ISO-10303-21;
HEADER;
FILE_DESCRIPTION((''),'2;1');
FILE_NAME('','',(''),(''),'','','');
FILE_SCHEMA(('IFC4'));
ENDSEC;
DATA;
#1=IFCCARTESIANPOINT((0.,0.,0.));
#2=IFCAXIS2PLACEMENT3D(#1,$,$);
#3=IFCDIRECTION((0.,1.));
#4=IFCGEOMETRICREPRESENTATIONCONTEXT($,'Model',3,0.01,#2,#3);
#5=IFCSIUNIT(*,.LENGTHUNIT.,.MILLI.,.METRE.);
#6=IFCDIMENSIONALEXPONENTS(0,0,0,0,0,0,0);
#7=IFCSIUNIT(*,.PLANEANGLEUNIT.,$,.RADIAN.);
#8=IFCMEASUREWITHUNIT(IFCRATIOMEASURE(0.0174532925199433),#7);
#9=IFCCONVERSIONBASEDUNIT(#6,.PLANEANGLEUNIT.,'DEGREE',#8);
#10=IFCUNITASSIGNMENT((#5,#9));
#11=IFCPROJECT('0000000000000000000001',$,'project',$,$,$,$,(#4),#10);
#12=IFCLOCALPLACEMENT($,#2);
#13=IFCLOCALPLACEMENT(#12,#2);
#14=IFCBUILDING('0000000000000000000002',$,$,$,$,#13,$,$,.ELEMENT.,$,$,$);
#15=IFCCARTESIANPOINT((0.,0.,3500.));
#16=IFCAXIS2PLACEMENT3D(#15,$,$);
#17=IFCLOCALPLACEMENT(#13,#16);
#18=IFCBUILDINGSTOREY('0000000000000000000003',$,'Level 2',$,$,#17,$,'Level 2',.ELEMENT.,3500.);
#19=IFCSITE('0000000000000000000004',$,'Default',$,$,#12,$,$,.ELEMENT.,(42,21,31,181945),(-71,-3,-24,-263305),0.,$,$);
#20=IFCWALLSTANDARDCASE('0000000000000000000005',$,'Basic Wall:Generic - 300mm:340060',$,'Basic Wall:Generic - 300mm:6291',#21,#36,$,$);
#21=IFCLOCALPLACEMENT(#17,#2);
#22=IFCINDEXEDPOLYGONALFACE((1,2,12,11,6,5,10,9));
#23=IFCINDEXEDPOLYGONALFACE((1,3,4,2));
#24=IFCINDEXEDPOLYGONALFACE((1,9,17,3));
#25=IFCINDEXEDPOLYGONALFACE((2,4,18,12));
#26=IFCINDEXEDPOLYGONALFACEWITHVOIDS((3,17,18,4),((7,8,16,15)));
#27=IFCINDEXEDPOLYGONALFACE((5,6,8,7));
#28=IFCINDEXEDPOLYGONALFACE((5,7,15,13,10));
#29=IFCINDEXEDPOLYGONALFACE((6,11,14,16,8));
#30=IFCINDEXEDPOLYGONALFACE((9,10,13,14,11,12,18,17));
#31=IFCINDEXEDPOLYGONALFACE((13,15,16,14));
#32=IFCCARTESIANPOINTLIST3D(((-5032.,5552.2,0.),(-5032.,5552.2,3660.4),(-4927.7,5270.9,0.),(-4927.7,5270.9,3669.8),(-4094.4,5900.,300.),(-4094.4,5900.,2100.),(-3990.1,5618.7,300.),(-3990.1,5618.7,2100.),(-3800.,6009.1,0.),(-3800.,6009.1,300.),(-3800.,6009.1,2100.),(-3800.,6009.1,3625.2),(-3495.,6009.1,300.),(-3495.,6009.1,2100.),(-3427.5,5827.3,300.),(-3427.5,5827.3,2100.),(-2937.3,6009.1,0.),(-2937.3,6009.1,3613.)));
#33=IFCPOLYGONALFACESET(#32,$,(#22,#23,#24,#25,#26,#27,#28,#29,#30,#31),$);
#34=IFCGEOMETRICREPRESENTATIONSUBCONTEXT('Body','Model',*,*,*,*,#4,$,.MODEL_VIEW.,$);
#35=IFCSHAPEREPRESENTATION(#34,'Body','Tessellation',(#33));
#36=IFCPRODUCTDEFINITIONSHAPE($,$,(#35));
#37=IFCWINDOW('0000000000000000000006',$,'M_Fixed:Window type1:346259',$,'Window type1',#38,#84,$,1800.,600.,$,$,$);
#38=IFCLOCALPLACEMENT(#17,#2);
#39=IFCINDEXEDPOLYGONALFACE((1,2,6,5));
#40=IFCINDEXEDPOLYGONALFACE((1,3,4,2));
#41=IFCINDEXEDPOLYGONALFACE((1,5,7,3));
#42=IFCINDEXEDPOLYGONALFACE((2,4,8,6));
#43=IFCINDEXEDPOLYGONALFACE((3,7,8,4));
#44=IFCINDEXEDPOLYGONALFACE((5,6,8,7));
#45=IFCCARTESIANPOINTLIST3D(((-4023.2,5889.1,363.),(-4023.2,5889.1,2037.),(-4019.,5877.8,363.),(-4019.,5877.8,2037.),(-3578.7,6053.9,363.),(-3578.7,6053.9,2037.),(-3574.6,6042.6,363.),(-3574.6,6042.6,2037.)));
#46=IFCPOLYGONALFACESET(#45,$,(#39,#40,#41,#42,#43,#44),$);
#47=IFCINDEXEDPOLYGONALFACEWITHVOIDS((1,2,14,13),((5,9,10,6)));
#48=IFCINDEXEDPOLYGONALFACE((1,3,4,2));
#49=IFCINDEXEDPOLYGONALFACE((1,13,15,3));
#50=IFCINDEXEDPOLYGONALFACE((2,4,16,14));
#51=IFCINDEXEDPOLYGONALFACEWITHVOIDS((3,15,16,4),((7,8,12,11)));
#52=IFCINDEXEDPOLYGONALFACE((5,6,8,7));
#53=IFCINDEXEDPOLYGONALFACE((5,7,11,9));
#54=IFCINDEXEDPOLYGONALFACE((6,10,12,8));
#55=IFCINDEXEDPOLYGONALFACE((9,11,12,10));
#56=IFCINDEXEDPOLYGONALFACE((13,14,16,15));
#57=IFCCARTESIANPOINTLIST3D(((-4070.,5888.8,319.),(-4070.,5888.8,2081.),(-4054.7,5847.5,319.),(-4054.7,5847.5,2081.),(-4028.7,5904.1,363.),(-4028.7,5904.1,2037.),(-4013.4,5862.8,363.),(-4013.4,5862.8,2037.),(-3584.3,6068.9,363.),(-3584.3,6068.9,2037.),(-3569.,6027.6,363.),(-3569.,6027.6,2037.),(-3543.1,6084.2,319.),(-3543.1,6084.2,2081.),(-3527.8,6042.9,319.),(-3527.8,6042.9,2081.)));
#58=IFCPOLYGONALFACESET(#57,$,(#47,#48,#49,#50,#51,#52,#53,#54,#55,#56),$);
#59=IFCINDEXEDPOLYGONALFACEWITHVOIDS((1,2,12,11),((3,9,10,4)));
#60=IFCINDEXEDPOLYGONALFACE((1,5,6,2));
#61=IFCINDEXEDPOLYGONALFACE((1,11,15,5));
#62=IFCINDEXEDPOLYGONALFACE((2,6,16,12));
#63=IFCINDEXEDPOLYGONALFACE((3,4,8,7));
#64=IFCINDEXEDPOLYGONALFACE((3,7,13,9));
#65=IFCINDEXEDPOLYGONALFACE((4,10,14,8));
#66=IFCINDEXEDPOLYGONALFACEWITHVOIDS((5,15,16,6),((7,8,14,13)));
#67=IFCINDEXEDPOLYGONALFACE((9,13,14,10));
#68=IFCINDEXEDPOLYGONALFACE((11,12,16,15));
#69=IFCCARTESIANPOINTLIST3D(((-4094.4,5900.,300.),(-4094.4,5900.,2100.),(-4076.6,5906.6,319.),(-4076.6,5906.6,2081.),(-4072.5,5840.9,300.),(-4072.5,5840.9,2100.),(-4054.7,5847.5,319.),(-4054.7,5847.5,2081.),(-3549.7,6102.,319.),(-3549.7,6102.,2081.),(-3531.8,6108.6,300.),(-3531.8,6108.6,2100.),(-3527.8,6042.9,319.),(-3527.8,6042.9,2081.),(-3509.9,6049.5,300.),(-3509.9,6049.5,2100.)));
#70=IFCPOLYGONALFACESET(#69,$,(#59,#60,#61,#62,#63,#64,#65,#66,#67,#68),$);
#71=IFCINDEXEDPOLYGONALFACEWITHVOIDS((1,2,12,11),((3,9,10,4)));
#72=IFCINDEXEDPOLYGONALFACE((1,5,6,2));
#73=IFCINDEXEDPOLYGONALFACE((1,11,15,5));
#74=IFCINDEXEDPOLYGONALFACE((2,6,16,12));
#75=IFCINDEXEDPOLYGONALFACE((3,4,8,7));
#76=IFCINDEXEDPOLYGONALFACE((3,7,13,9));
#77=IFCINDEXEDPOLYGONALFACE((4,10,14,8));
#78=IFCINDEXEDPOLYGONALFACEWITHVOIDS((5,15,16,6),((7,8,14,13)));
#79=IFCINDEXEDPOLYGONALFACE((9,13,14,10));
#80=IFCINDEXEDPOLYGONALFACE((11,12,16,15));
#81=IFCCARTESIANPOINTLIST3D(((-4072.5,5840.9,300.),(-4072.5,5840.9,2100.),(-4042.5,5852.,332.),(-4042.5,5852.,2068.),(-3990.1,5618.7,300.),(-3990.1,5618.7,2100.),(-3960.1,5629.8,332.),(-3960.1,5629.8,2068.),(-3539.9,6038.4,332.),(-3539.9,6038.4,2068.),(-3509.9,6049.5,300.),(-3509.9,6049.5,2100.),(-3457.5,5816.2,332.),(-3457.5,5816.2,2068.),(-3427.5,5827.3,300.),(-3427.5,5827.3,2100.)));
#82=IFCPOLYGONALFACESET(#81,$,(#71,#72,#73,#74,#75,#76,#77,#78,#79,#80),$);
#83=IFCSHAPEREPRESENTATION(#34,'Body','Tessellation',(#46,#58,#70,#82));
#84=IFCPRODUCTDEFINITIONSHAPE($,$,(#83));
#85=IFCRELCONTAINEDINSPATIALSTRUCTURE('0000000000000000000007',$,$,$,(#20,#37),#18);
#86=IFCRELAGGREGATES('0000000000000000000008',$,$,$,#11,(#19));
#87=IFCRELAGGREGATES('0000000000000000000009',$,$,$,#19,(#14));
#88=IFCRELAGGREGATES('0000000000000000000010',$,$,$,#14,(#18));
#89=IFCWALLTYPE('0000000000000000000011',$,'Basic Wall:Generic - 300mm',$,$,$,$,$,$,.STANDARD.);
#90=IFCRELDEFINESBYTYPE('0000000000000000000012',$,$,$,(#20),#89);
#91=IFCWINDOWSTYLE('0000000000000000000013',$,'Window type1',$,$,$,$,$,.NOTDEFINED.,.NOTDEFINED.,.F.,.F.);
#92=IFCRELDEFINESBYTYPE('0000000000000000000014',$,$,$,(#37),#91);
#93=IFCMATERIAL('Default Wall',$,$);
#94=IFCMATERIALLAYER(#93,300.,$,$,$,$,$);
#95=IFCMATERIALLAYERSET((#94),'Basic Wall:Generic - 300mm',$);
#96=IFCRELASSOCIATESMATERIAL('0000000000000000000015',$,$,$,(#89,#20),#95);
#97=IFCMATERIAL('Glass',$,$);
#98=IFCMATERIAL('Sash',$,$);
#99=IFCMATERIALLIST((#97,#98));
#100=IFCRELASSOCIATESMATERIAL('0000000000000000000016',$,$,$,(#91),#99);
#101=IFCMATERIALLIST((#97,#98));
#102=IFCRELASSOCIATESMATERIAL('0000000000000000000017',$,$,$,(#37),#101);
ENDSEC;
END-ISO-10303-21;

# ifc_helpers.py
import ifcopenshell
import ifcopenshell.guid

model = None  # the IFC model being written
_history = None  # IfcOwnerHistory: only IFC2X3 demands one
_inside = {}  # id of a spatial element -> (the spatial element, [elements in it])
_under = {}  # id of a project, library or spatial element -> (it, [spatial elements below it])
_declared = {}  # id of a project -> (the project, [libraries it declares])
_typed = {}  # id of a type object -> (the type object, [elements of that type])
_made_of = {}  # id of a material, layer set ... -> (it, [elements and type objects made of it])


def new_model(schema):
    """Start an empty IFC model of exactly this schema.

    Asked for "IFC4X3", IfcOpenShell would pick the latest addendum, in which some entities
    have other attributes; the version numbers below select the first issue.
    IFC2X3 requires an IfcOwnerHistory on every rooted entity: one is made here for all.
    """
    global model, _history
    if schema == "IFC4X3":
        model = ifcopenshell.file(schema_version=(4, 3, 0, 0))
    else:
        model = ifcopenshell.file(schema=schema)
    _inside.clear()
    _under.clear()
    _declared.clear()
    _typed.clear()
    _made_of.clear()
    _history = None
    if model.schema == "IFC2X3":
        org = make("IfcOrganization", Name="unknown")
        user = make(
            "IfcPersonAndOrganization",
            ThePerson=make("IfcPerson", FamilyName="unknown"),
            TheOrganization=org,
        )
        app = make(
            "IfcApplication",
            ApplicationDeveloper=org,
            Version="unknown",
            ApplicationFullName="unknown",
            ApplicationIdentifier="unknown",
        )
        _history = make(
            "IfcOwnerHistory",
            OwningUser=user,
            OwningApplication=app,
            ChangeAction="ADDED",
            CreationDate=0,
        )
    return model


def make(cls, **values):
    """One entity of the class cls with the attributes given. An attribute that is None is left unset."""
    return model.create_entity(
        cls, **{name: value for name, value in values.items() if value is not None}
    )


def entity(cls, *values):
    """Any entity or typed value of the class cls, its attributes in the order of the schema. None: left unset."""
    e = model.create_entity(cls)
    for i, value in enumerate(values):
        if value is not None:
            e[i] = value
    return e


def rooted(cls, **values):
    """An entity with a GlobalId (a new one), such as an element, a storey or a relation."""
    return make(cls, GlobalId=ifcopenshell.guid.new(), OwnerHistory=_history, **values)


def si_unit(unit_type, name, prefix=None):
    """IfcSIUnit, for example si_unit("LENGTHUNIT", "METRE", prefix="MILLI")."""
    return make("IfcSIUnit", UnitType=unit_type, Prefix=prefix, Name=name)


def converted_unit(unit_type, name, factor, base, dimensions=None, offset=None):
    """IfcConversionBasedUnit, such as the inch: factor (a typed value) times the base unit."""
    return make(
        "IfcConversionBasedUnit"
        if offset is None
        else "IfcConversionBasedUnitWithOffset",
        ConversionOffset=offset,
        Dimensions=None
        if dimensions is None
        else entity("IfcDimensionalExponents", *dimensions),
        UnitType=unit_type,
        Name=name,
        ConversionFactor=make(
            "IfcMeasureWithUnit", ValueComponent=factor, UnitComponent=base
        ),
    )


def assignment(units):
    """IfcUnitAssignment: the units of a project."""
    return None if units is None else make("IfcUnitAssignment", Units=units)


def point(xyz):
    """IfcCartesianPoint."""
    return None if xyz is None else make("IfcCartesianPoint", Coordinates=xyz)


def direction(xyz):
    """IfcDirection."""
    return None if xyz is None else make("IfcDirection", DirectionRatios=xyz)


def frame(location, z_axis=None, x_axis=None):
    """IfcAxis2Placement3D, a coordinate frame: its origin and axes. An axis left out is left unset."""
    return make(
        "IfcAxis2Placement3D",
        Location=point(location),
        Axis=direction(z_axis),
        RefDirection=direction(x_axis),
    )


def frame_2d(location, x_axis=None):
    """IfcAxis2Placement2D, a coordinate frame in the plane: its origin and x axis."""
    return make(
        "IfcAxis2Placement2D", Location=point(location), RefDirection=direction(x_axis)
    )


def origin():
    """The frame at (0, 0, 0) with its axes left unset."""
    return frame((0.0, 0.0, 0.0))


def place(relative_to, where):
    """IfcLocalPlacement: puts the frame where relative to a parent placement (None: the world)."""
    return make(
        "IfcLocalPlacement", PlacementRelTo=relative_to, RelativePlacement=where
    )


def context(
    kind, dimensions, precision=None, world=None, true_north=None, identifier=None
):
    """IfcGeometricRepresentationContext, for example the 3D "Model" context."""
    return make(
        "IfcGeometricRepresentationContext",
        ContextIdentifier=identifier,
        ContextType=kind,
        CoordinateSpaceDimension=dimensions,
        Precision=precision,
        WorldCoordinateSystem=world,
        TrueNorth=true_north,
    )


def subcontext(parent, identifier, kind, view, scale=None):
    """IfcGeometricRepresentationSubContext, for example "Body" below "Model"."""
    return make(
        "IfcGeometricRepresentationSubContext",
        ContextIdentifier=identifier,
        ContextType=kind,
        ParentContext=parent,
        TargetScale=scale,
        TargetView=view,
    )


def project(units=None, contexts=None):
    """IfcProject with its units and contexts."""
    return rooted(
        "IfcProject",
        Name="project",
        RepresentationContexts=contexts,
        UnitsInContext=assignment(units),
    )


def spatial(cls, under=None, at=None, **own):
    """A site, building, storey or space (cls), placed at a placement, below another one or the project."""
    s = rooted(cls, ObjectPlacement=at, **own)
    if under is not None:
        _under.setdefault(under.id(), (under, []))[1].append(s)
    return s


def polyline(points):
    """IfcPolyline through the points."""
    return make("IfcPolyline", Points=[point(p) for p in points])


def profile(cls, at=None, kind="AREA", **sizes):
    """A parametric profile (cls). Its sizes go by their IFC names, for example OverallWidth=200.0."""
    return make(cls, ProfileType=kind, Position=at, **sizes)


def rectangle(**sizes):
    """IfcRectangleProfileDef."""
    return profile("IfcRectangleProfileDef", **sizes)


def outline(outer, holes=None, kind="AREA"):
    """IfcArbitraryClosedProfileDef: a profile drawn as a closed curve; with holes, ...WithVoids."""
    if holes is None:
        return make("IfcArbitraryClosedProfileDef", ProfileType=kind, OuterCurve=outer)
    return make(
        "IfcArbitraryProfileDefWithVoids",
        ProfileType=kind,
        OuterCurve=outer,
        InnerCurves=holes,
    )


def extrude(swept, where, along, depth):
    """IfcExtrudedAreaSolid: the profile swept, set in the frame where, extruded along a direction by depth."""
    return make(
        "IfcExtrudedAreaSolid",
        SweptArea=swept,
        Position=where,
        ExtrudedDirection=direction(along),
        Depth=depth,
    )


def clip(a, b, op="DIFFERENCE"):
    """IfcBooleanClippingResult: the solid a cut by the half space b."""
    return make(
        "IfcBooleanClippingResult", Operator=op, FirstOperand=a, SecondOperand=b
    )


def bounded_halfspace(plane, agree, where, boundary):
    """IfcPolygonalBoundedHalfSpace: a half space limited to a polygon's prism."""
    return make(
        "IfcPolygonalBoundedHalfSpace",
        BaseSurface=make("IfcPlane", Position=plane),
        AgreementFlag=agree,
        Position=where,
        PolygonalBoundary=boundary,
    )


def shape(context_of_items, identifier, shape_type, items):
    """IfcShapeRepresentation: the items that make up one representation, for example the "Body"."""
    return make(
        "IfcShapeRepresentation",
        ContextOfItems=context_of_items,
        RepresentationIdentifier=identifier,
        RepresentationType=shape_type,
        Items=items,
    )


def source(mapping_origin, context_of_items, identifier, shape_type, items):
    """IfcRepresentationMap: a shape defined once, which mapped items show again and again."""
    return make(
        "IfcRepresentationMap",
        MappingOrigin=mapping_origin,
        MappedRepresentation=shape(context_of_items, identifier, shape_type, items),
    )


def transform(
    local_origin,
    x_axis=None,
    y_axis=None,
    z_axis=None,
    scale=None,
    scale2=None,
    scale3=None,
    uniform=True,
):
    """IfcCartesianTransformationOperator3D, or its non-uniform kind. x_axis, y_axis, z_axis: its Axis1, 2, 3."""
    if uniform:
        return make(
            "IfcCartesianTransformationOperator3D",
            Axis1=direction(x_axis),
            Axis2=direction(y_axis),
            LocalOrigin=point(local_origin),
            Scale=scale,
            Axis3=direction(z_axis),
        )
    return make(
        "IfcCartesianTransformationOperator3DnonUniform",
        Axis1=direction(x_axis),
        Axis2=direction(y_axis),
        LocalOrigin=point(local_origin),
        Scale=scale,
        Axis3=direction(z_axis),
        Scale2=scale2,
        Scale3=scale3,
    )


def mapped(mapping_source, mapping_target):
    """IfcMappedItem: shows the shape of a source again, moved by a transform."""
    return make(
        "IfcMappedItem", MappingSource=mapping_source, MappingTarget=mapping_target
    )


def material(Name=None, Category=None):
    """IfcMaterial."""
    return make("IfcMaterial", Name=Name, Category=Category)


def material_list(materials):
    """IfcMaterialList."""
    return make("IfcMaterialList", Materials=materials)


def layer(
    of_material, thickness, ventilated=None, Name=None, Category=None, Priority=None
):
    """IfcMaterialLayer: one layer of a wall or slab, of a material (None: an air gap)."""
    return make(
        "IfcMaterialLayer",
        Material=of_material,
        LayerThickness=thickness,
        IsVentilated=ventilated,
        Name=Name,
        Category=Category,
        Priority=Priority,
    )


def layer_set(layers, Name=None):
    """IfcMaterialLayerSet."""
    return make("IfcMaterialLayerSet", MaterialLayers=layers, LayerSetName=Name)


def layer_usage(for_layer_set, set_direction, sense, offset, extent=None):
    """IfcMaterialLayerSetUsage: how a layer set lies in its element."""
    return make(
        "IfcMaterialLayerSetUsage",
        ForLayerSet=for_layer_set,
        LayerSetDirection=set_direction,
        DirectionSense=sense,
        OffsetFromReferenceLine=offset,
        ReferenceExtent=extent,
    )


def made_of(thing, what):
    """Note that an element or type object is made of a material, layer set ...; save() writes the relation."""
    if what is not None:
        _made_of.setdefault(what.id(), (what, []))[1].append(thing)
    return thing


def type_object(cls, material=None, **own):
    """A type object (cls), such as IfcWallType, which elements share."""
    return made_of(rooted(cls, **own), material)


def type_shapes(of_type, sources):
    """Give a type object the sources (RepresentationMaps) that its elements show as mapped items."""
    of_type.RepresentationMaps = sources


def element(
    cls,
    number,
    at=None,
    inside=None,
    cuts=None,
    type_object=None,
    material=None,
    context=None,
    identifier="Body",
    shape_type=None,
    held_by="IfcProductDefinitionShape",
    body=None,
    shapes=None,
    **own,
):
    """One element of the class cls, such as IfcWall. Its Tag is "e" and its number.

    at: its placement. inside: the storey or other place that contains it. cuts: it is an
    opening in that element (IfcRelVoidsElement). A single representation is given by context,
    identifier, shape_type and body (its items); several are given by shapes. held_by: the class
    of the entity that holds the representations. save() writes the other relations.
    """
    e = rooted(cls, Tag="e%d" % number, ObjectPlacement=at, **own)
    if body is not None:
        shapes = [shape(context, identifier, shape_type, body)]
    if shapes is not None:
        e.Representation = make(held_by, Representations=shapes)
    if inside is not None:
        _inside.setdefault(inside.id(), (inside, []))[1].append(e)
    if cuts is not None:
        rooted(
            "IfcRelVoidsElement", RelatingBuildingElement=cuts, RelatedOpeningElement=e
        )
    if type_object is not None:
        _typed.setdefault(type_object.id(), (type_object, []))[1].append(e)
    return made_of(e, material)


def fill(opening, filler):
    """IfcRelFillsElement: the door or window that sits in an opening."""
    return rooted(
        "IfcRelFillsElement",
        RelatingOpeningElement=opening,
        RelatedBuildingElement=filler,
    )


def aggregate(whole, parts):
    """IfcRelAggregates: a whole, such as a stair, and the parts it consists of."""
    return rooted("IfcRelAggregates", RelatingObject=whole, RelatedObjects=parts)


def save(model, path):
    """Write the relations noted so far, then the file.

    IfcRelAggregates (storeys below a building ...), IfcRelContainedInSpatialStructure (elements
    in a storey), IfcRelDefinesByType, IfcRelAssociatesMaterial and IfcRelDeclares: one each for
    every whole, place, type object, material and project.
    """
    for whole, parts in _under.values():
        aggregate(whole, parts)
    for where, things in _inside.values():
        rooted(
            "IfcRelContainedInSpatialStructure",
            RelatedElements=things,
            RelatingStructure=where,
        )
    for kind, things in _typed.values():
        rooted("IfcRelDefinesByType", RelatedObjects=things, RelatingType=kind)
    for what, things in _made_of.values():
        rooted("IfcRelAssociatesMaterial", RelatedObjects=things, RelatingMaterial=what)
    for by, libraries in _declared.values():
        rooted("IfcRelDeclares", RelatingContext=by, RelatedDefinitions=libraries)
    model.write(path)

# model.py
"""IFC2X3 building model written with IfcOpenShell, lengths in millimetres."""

from ifc_helpers import new_model, entity, si_unit, converted_unit, direction, frame, frame_2d, origin, place, context, subcontext, project, spatial, polyline, rectangle, outline, extrude, clip, bounded_halfspace, source, transform, mapped, material, material_list, layer, layer_set, layer_usage, type_object, type_shapes, element, fill, save


model = new_model("IFC2X3")

# Units and contexts
model_context = context("Model", 3, precision=0.01, world=origin(), true_north=direction((0.0, 1.0)))
body_context = subcontext(model_context, "Body", "Model", "MODEL_VIEW")
ifc_project = project(units=[si_unit("LENGTHUNIT", "METRE", prefix="MILLI"), converted_unit("PLANEANGLEUNIT", "DEGREE", entity("IfcRatioMeasure", 0.0174532925199433), si_unit("PLANEANGLEUNIT", "RADIAN"), dimensions=[0, 0, 0, 0, 0, 0, 0])], contexts=[model_context])

# Site, building, storey
site_placement = place(None, origin())
site = spatial("IfcSite", under=ifc_project, at=site_placement, Name="Default", CompositionType="ELEMENT", RefLatitude=(42, 21, 31, 181945), RefLongitude=(-71, -3, -24, -263305), RefElevation=0.0)
building_placement = place(site_placement, origin())
building = spatial("IfcBuilding", under=site, at=building_placement, CompositionType="ELEMENT")
storey_placement = place(building_placement, frame((0.0, 0.0, 3500.0)))
storey = spatial("IfcBuildingStorey", under=building, at=storey_placement, Name="Level 2", LongName="Level 2", CompositionType="ELEMENT", Elevation=3500.0)

# Shared definitions
ifc_material_1 = material(Name="Default Wall")
ifc_layer_1 = layer(ifc_material_1, 300.0)
ifc_layer_set_1 = layer_set([ifc_layer_1], Name="Basic Wall:Generic - 300mm")
wall_type = type_object("IfcWallType", Name="Basic Wall:Generic - 300mm", PredefinedType="STANDARD", material=ifc_layer_set_1)
ifc_material_2 = material(Name="Glass")
ifc_material_3 = material(Name="Sash")

# Wall, opening, window
ifc_layer_usage_1 = layer_usage(ifc_layer_set_1, "AXIS2", "NEGATIVE", 150.0)
wall_1_placement = place(storey_placement, frame((-4979.8, 5411.6, 0.0), z_axis=(0.0, 0.0, 1.0), x_axis=(0.937589, 0.347744, 0.0)))
wall_1 = element("IfcWallStandardCase", 1, at=wall_1_placement, inside=storey, type_object=wall_type, material=ifc_layer_usage_1, Name="Basic Wall:Generic - 300mm:340060", ObjectType="Basic Wall:Generic - 300mm:6291", context=body_context, shape_type="Clipping", body=[
    clip(extrude(outline(polyline([(2122.8, -150.0), (1314.0, 150.0), (0.0, 150.0), (0.0, -150.0), (2122.8, -150.0)])), origin(), (0.0, 0.0, 1.0), 3669.8), bounded_halfspace(frame((0.0, -150.0, 3669.8), z_axis=(0.026731, 0.031465, 0.999147), x_axis=(-0.76211, 0.647447, 0.0)), False, frame((0.0, -150.0, 3669.8)), polyline([(0.0, 0.0), (2122.8, 0.0), (1314.0, 300.0), (0.0, 300.0), (0.0, 0.0)]))),
])
opening_1_placement = place(wall_1_placement, frame((1000.0, -150.0, 300.0)))
opening_1 = element("IfcOpeningElement", 2, at=opening_1_placement, cuts=wall_1, ObjectType="Opening", context=body_context, shape_type="SweptSolid", body=[
    extrude(rectangle(XDim=1800.0, YDim=600.0, at=frame_2d((900.0, 300.0), x_axis=(1.0, 0.0))), frame((0.0, 0.0, 0.0), z_axis=(0.0, 1.0, 0.0), x_axis=(0.0, 0.0, 1.0)), (0.0, 0.0, 1.0), 300.0),
])
ifc_material_list_1 = material_list([ifc_material_2, ifc_material_3])
ifc_material_list_2 = material_list([ifc_material_2, ifc_material_3])
window_style_1 = type_object("IfcWindowStyle", Name="Window type1", ConstructionType="NOTDEFINED", OperationType="NOTDEFINED", ParameterTakesPrecedence=False, Sizeable=False, material=ifc_material_list_2)
shared_shape_1 = source(origin(), body_context, "Body", "SweptSolid", [
    extrude(rectangle(XDim=474.0, YDim=12.0, at=frame_2d((0.0, 0.0), x_axis=(1.0, 0.0))), frame((300.0, 285.0, 63.0), z_axis=(0.0, 0.0, 1.0), x_axis=(-1.0, 0.0, 0.0)), (0.0, 0.0, 1.0), 1674.0),
    extrude(outline(polyline([(-281.0, -881.0), (281.0, -881.0), (281.0, 881.0), (-281.0, 881.0), (-281.0, -881.0)]), holes=[polyline([(-237.0, -837.0), (-237.0, 837.0), (237.0, 837.0), (237.0, -837.0), (-237.0, -837.0)])]), frame((300.0, 307.0, 900.0), z_axis=(0.0, -1.0, 0.0), x_axis=(-1.0, 0.0, 0.0)), (0.0, 0.0, 1.0), 44.0),
    extrude(outline(polyline([(-300.0, -900.0), (300.0, -900.0), (300.0, 900.0), (-300.0, 900.0), (-300.0, -900.0)]), holes=[polyline([(-281.0, -881.0), (-281.0, 881.0), (281.0, 881.0), (281.0, -881.0), (-281.0, -881.0)])]), frame((300.0, 326.0, 900.0), z_axis=(0.0, -1.0, 0.0), x_axis=(-1.0, 0.0, 0.0)), (0.0, 0.0, 1.0), 63.0),
    extrude(outline(polyline([(-300.0, -900.0), (300.0, -900.0), (300.0, 900.0), (-300.0, 900.0), (-300.0, -900.0)]), holes=[polyline([(-268.0, -868.0), (-268.0, 868.0), (268.0, 868.0), (268.0, -868.0), (-268.0, -868.0)])]), frame((300.0, 263.0, 900.0), z_axis=(0.0, -1.0, 0.0), x_axis=(-1.0, 0.0, 0.0)), (0.0, 0.0, 1.0), 237.0),
])
type_shapes(window_style_1, [shared_shape_1])
window_1_placement = place(opening_1_placement, frame((0.0, -26.0, 0.0)))
window_1 = element("IfcWindow", 3, at=window_1_placement, inside=storey, type_object=window_style_1, material=ifc_material_list_1, Name="M_Fixed:Window type1:346259", ObjectType="Window type1", OverallHeight=1800.0, OverallWidth=600.0, context=body_context, shape_type="MappedRepresentation", body=[
    mapped(shared_shape_1, transform((0.0, 0.0, 0.0), scale=1.0)),
])
fill(opening_1, window_1)

save(model, "model.ifc")
